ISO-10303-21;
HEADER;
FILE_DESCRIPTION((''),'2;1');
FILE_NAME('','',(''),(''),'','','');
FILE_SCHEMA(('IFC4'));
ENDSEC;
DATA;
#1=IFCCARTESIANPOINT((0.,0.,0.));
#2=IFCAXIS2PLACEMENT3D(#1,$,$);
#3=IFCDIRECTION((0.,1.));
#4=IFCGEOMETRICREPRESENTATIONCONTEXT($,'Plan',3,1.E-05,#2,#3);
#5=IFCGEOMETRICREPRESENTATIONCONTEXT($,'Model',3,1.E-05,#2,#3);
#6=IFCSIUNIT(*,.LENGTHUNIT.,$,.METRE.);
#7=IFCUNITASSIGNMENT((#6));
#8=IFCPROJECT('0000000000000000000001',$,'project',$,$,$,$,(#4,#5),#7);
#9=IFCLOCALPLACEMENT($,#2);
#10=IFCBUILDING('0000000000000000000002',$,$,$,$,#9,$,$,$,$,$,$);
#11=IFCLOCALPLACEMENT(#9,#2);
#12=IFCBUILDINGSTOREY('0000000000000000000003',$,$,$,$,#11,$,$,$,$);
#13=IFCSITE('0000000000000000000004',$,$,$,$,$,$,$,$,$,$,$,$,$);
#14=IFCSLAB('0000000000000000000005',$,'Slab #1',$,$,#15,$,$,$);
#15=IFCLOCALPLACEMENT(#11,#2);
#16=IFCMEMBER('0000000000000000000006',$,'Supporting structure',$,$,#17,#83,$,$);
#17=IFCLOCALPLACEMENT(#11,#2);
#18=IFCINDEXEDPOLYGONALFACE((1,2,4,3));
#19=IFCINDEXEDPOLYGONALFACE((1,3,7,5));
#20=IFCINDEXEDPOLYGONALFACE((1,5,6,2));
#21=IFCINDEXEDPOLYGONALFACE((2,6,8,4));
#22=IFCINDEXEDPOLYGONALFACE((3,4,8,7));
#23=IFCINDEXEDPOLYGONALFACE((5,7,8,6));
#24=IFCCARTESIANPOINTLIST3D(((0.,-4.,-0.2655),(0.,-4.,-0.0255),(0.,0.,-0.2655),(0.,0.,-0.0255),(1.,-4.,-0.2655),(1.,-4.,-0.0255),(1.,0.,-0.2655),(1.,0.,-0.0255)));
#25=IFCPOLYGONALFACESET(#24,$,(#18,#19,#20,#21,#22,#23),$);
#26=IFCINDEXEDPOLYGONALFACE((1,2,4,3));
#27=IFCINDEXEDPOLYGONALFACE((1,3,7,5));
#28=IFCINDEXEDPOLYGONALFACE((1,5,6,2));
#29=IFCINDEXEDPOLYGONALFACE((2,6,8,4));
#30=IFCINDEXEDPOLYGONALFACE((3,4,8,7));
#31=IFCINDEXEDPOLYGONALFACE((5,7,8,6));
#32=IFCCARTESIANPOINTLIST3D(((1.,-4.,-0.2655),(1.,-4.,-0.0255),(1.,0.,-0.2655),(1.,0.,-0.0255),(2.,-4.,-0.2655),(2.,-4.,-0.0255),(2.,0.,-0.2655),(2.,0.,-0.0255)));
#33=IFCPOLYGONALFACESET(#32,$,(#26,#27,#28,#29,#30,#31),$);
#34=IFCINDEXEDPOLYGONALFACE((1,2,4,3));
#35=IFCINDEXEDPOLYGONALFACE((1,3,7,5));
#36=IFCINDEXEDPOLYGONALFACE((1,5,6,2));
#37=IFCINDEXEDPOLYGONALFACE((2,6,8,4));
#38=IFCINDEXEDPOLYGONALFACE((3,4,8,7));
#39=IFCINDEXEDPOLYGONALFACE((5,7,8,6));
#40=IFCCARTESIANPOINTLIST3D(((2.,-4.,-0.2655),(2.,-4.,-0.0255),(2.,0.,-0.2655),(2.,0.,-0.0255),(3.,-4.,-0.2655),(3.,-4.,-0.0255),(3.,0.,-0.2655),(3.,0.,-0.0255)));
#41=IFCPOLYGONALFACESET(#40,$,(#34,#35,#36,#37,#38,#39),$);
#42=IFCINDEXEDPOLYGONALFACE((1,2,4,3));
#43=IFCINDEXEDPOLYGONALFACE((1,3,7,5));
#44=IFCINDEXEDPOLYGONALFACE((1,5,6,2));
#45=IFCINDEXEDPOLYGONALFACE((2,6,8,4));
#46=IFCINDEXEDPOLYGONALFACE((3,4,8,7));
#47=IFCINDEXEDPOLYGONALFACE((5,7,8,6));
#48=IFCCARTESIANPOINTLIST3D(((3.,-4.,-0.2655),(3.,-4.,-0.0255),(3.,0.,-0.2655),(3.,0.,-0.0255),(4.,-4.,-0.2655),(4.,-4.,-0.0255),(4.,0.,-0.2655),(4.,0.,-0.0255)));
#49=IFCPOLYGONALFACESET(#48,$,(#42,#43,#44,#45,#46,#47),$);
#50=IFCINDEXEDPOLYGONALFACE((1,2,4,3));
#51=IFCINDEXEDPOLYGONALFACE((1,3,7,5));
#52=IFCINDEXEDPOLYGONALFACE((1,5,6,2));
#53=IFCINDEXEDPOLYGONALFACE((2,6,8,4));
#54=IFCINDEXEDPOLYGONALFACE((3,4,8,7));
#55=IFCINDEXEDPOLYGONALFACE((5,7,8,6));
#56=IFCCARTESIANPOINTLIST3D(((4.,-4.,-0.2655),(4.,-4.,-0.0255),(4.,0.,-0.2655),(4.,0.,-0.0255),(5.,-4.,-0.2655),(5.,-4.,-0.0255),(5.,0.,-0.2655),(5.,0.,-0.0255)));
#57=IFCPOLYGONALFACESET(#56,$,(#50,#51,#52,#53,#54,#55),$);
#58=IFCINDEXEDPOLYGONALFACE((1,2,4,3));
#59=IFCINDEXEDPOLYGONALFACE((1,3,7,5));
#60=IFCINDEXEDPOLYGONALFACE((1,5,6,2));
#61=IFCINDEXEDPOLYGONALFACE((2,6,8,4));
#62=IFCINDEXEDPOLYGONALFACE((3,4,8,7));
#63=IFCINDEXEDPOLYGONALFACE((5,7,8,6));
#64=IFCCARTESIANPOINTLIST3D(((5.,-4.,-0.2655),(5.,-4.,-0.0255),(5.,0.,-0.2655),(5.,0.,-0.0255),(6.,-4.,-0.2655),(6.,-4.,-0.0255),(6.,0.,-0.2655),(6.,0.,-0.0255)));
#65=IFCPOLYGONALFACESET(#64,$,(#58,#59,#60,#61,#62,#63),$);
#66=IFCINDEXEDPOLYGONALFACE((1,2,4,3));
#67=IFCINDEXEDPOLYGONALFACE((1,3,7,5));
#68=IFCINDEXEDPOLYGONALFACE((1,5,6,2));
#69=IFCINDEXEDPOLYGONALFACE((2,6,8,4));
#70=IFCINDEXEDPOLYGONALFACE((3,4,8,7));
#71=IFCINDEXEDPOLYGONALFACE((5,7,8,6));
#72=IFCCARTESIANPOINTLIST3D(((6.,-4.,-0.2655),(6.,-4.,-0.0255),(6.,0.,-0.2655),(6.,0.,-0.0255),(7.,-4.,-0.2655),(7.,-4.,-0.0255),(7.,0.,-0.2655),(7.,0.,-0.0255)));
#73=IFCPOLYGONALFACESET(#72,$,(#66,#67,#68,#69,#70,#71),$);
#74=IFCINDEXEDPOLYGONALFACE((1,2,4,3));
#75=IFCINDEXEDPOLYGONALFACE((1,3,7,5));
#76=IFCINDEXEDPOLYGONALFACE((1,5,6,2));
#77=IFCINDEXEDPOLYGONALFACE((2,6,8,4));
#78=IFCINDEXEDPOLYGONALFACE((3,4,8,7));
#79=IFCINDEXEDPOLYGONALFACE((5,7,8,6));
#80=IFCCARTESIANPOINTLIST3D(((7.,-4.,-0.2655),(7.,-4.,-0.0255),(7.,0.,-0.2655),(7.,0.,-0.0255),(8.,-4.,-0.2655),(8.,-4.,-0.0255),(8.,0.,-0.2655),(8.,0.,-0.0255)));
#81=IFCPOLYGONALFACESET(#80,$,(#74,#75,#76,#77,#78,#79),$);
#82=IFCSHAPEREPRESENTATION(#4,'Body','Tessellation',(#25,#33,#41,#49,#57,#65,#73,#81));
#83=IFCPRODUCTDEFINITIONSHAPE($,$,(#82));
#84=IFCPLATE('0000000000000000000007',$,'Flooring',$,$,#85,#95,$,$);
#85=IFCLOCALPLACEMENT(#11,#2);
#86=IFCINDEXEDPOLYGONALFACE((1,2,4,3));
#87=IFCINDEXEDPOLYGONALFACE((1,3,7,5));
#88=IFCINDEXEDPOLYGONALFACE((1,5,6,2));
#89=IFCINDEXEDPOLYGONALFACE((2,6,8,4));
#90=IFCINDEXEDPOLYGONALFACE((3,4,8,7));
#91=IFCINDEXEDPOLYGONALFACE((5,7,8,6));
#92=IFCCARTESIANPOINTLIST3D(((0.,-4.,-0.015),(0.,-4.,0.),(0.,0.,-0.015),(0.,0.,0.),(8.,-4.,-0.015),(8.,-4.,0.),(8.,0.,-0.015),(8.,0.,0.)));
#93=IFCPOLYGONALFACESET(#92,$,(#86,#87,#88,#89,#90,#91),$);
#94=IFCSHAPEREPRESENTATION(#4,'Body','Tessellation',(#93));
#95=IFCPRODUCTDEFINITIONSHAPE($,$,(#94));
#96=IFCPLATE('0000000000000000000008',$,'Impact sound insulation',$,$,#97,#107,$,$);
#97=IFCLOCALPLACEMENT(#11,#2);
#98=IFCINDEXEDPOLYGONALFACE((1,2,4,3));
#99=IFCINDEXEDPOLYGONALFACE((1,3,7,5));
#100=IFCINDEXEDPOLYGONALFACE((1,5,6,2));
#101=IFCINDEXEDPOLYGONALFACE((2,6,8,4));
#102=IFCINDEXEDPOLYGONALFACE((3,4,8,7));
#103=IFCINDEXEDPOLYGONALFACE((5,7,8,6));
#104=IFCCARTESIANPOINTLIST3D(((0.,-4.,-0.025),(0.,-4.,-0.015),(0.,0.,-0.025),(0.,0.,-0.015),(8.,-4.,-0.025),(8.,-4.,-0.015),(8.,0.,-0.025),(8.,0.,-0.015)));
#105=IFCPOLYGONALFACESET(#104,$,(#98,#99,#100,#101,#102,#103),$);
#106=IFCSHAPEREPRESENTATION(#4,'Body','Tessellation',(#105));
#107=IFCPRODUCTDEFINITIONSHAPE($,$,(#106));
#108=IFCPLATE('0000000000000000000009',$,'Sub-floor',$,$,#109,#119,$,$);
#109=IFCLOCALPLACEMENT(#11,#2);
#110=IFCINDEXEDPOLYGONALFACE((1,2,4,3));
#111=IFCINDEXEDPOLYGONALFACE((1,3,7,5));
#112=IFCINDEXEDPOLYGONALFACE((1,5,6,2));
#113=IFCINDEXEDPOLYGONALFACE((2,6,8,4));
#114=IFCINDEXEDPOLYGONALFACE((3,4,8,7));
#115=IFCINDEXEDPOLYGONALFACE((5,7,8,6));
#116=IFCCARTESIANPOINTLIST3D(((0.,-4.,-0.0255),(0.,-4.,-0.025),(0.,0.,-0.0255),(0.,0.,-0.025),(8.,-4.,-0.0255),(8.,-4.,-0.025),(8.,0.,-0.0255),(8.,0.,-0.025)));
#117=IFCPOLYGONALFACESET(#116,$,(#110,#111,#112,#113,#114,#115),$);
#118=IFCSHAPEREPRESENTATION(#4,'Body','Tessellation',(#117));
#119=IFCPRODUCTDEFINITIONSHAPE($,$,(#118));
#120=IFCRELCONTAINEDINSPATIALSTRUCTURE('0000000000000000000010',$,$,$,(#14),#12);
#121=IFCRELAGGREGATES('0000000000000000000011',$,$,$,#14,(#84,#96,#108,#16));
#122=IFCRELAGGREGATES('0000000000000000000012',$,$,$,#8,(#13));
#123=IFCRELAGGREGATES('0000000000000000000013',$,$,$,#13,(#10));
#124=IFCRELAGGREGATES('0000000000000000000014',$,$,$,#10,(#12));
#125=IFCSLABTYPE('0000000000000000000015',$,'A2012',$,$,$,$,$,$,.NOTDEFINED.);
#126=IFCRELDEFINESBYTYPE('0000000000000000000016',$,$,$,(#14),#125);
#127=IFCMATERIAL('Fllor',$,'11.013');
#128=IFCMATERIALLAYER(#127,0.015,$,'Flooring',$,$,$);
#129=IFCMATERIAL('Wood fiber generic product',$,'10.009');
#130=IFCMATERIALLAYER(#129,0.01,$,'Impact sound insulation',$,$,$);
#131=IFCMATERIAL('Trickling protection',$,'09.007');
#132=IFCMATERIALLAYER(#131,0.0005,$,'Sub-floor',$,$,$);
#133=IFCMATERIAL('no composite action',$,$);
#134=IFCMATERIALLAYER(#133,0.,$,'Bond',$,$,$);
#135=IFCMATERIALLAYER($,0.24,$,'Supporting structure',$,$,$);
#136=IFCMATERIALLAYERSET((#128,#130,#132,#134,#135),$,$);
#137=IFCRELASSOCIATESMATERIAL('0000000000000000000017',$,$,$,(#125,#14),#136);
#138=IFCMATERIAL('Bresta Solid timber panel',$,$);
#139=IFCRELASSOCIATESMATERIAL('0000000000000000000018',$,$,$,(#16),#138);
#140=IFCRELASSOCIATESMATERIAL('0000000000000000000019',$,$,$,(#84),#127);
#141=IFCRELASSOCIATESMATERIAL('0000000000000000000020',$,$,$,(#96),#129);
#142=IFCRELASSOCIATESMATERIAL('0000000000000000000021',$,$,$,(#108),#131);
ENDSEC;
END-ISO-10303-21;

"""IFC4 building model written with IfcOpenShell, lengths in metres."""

from ifc_helpers import new_model, si_unit, direction, frame, frame_2d, origin, origin_with_axes, place, context, project, spatial, rectangle, extrude, material, layer, layer_set, type_object, element, aggregate, save


model = new_model("IFC4")

# Units and contexts
plan_context = context("Plan", 3, precision=1e-05, world=origin(), true_north=direction((0.0, 1.0)))
model_context = context("Model", 3, precision=1e-05, world=origin(), true_north=direction((0.0, 1.0)))
ifc_project = project(units=[si_unit("LENGTHUNIT", "METRE")], contexts=[plan_context, model_context])

# Site, building, storey
site = spatial("IfcSite", under=ifc_project)
building_placement = place(None, origin())
building = spatial("IfcBuilding", under=site, at=building_placement)
storey_placement = place(building_placement, origin())
storey = spatial("IfcBuildingStorey", under=building, at=storey_placement)

# Slab, member, plates
ifc_material_1 = material(Name="Fllor", Category="11.013")
ifc_layer_1 = layer(ifc_material_1, 0.015, Name="Flooring")
ifc_material_2 = material(Name="Wood fiber generic product", Category="10.009")
ifc_layer_2 = layer(ifc_material_2, 0.01, Name="Impact sound insulation")
ifc_material_3 = material(Name="Trickling protection", Category="09.007")
ifc_layer_3 = layer(ifc_material_3, 0.0005, Name="Sub-floor")
ifc_material_4 = material(Name="no composite action")
ifc_layer_4 = layer(ifc_material_4, 0.0, Name="Bond")
ifc_layer_5 = layer(None, 0.24, Name="Supporting structure")
ifc_layer_set = layer_set([ifc_layer_1, ifc_layer_2, ifc_layer_3, ifc_layer_4, ifc_layer_5])
slab_type = type_object("IfcSlabType", Name="A2012", PredefinedType="NOTDEFINED", material=ifc_layer_set)
slab_placement = place(None, frame((0.0, 0.0, 0.0), z_axis=(0.0, 0.0, -1.0), x_axis=(1.0, 0.0, 0.0)))
slab = element("IfcSlab", 1, at=slab_placement, inside=storey, type_object=slab_type, material=ifc_layer_set, Name="Slab #1")
ifc_material_5 = material(Name="Bresta Solid timber panel")
member_placement = place(slab_placement, origin())
member = element("IfcMember", 2, at=member_placement, material=ifc_material_5, Name="Supporting structure", context=plan_context, shape_type="SweptSolid", body=[
    extrude(rectangle(XDim=1.0, YDim=0.24, at=frame_2d((0.5, 0.12), x_axis=(1.0, 0.0))), frame((0.0, 4.0, 0.0255), z_axis=(0.0, -1.0, 0.0), x_axis=(1.0, 0.0, 0.0)), (0.0, 0.0, 1.0), 4.0),
    extrude(rectangle(XDim=1.0, YDim=0.24, at=frame_2d((0.5, 0.12), x_axis=(1.0, 0.0))), frame((1.0, 4.0, 0.0255), z_axis=(0.0, -1.0, 0.0), x_axis=(1.0, 0.0, 0.0)), (0.0, 0.0, 1.0), 4.0),
    extrude(rectangle(XDim=1.0, YDim=0.24, at=frame_2d((0.5, 0.12), x_axis=(1.0, 0.0))), frame((2.0, 4.0, 0.0255), z_axis=(0.0, -1.0, 0.0), x_axis=(1.0, 0.0, 0.0)), (0.0, 0.0, 1.0), 4.0),
    extrude(rectangle(XDim=1.0, YDim=0.24, at=frame_2d((0.5, 0.12), x_axis=(1.0, 0.0))), frame((3.0, 4.0, 0.0255), z_axis=(0.0, -1.0, 0.0), x_axis=(1.0, 0.0, 0.0)), (0.0, 0.0, 1.0), 4.0),
    extrude(rectangle(XDim=1.0, YDim=0.24, at=frame_2d((0.5, 0.12), x_axis=(1.0, 0.0))), frame((4.0, 4.0, 0.0255), z_axis=(0.0, -1.0, 0.0), x_axis=(1.0, 0.0, 0.0)), (0.0, 0.0, 1.0), 4.0),
    extrude(rectangle(XDim=1.0, YDim=0.24, at=frame_2d((0.5, 0.12), x_axis=(1.0, 0.0))), frame((5.0, 4.0, 0.0255), z_axis=(0.0, -1.0, 0.0), x_axis=(1.0, 0.0, 0.0)), (0.0, 0.0, 1.0), 4.0),
    extrude(rectangle(XDim=1.0, YDim=0.24, at=frame_2d((0.5, 0.12), x_axis=(1.0, 0.0))), frame((6.0, 4.0, 0.0255), z_axis=(0.0, -1.0, 0.0), x_axis=(1.0, 0.0, 0.0)), (0.0, 0.0, 1.0), 4.0),
    extrude(rectangle(XDim=1.0, YDim=0.24, at=frame_2d((0.5, 0.12), x_axis=(1.0, 0.0))), frame((7.0, 4.0, 0.0255), z_axis=(0.0, -1.0, 0.0), x_axis=(1.0, 0.0, 0.0)), (0.0, 0.0, 1.0), 4.0),
])
plate_1_placement = place(slab_placement, origin())
plate_1 = element("IfcPlate", 3, at=plate_1_placement, material=ifc_material_1, Name="Flooring", context=plan_context, shape_type="SweptSolid", body=[
    extrude(rectangle(XDim=8.0, YDim=4.0, at=frame_2d((4.0, 2.0), x_axis=(1.0, 0.0))), origin_with_axes(), (0.0, 0.0, 1.0), 0.015),
])
plate_2_placement = place(slab_placement, origin())
plate_2 = element("IfcPlate", 4, at=plate_2_placement, material=ifc_material_2, Name="Impact sound insulation", context=plan_context, shape_type="SweptSolid", body=[
    extrude(rectangle(XDim=8.0, YDim=4.0, at=frame_2d((4.0, 2.0), x_axis=(1.0, 0.0))), frame((0.0, 0.0, 0.015), z_axis=(0.0, 0.0, 1.0), x_axis=(1.0, 0.0, 0.0)), (0.0, 0.0, 1.0), 0.01),
])
plate_3_placement = place(slab_placement, origin())
plate_3 = element("IfcPlate", 5, at=plate_3_placement, material=ifc_material_3, Name="Sub-floor", context=plan_context, shape_type="SweptSolid", body=[
    extrude(rectangle(XDim=8.0, YDim=4.0, at=frame_2d((4.0, 2.0), x_axis=(1.0, 0.0))), frame((0.0, 0.0, 0.025), z_axis=(0.0, 0.0, 1.0), x_axis=(1.0, 0.0, 0.0)), (0.0, 0.0, 1.0), 0.0005),
])
aggregate(slab, [plate_1, plate_2, plate_3, member])

save(model, "model.ifc")
